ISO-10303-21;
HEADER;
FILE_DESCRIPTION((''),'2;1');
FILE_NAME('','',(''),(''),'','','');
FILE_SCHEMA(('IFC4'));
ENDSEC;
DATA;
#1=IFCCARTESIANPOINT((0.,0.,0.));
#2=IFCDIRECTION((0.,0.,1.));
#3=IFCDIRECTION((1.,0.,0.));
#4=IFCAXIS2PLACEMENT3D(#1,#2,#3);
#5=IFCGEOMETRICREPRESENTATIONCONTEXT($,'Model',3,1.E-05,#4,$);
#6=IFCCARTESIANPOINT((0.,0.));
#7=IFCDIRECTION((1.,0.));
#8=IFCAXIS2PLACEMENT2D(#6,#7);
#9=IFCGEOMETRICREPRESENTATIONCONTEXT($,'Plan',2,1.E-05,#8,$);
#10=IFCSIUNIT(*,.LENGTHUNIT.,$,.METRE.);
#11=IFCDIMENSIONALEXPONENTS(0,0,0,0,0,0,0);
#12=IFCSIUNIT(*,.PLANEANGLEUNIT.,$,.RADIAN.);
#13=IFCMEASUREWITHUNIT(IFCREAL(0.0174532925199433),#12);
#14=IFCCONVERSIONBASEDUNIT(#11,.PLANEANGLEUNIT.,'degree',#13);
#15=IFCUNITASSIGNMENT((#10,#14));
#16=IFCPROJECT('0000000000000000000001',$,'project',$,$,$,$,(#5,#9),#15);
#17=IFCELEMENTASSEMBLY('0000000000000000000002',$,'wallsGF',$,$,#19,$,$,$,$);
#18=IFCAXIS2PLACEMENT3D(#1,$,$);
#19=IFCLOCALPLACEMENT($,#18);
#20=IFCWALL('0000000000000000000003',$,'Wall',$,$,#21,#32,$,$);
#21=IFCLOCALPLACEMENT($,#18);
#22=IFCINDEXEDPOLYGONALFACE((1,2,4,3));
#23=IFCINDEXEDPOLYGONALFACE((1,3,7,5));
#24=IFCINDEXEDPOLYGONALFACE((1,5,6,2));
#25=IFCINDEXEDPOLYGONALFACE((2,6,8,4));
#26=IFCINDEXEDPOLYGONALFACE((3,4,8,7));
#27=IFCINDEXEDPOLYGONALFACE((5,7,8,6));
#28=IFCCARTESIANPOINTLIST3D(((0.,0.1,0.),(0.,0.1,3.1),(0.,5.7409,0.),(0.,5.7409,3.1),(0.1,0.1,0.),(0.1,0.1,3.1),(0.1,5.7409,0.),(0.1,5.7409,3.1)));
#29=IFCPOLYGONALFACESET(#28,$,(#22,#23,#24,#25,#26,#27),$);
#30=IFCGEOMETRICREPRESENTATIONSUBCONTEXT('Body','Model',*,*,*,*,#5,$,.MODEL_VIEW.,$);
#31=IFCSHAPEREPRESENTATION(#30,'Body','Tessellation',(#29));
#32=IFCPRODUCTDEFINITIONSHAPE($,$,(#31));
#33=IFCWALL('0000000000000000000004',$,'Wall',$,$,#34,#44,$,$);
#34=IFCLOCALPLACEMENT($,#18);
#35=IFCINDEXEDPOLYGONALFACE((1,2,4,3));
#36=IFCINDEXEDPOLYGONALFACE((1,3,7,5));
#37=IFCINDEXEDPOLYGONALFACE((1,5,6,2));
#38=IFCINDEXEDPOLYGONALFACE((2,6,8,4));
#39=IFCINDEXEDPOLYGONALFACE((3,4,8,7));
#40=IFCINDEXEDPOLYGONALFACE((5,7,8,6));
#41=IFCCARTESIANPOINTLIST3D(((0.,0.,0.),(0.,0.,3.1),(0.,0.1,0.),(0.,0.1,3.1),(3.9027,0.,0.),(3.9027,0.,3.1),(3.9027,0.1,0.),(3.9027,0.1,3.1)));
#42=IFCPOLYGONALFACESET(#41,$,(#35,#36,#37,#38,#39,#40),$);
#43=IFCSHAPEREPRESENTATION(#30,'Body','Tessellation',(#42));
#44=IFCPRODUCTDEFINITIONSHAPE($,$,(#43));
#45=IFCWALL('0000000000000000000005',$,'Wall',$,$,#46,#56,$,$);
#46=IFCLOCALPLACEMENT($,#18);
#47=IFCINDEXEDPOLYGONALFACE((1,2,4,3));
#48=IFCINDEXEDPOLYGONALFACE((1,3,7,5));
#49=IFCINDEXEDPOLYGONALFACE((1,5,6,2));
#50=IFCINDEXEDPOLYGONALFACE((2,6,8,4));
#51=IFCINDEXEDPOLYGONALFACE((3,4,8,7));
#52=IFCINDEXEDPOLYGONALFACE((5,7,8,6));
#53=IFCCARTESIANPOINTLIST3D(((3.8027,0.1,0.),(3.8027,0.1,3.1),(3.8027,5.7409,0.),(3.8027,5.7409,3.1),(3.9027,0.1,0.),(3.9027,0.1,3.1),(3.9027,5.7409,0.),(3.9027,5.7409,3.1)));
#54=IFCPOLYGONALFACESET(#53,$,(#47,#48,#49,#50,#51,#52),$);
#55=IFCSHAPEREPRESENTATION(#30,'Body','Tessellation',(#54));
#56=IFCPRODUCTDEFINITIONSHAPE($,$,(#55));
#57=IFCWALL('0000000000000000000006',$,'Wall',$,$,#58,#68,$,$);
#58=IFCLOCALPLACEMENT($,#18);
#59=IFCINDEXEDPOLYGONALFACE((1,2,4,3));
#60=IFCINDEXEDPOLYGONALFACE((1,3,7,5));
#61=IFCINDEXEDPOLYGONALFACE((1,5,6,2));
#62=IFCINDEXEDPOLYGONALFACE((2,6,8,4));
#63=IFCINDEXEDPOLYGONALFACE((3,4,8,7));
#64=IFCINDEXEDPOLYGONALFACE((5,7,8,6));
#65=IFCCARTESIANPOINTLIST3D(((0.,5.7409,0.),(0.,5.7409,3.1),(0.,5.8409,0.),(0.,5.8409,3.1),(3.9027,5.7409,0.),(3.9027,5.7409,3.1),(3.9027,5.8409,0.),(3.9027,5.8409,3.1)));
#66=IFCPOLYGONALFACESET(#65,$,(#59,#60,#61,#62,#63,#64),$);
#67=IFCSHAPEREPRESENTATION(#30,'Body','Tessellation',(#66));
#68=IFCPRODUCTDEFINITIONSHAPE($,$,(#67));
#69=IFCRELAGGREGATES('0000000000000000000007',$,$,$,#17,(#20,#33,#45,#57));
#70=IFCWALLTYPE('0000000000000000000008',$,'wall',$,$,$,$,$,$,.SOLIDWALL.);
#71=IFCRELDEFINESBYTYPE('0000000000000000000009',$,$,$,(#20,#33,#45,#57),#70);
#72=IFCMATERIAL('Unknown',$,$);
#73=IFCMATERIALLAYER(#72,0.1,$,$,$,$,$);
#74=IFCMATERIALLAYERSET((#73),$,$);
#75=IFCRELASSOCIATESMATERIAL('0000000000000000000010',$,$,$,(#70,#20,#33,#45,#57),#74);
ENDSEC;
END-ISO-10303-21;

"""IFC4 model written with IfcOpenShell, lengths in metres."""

from ifc_helpers import new_model, entity, si_unit, converted_unit, frame, origin_with_axes, origin_2d_with_axis, place, context, subcontext, project, indexed_curve, outline, extrude, clip, halfspace, material, layer, layer_set, layer_usage, type_object, element, aggregate, save


model = new_model("IFC4")

# Units and contexts
model_context = context("Model", 3, precision=1e-05, world=origin_with_axes())
plan_context = context("Plan", 2, precision=1e-05, world=origin_2d_with_axis())
body_context = subcontext(model_context, "Body", "Model", "MODEL_VIEW")
ifc_project = project(units=[si_unit("LENGTHUNIT", "METRE"), converted_unit("PLANEANGLEUNIT", "degree", entity("IfcReal", 0.0174532925199433), si_unit("PLANEANGLEUNIT", "RADIAN"), dimensions=[0, 0, 0, 0, 0, 0, 0])], contexts=[model_context, plan_context])

# Element assembly, walls
placement_1 = place(None, origin_with_axes())
placement_2 = place(placement_1, origin_with_axes())
placement_3 = place(placement_2, origin_with_axes())
assembly_placement = place(placement_3, origin_with_axes())
assembly = element("IfcElementAssembly", 1, at=assembly_placement, Name="wallsGF")
ifc_material = material(Name="Unknown")
ifc_layer = layer(ifc_material, 0.1)
ifc_layer_set = layer_set([ifc_layer])
ifc_layer_usage_1 = layer_usage(ifc_layer_set, "AXIS2", "POSITIVE", 0.0)
wall_type = type_object("IfcWallType", Name="wall", PredefinedType="SOLIDWALL", material=ifc_layer_set)
wall_1_placement = place(assembly_placement, frame((0.0, 5.7409, 0.0), z_axis=(0.0, 0.0, 1.0), x_axis=(0.0, -1.0, 0.0)))
wall_1 = element("IfcWall", 2, at=wall_1_placement, type_object=wall_type, material=ifc_layer_usage_1, Name="Wall", context=body_context, shape_type="Clipping", body=[
    clip(extrude(outline(indexed_curve([(0.0, 0.0), (0.0, 0.1), (5.6409, 0.1), (5.6409, 0.0), (0.0, 0.0)], self_intersect=False)), origin_with_axes(), (0.0, 0.0, 1.0), 3.1), halfspace(frame((0.0, 0.0, 3.1), z_axis=(0.0, 0.0, 1.0), x_axis=(-1.0, 0.0, 0.0)), False)),
])
ifc_layer_usage_2 = layer_usage(ifc_layer_set, "AXIS2", "POSITIVE", 0.0)
wall_2_placement = place(assembly_placement, origin_with_axes())
wall_2 = element("IfcWall", 3, at=wall_2_placement, type_object=wall_type, material=ifc_layer_usage_2, Name="Wall", context=body_context, shape_type="Clipping", body=[
    clip(extrude(outline(indexed_curve([(0.0, 0.0), (0.0, 0.1), (3.9027, 0.1), (3.9027, 0.0), (0.0, 0.0)], self_intersect=False)), origin_with_axes(), (0.0, 0.0, 1.0), 3.1), halfspace(frame((0.0, 0.0, 3.1), z_axis=(0.0, 0.0, 1.0), x_axis=(-1.0, 0.0, 0.0)), False)),
])
ifc_layer_usage_3 = layer_usage(ifc_layer_set, "AXIS2", "POSITIVE", 0.0)
wall_3_placement = place(assembly_placement, frame((3.8027, 5.7409, 0.0), z_axis=(0.0, 0.0, 1.0), x_axis=(0.0, -1.0, 0.0)))
wall_3 = element("IfcWall", 4, at=wall_3_placement, type_object=wall_type, material=ifc_layer_usage_3, Name="Wall", context=body_context, shape_type="Clipping", body=[
    clip(extrude(outline(indexed_curve([(0.0, 0.0), (0.0, 0.1), (5.6409, 0.1), (5.6409, 0.0), (0.0, 0.0)], self_intersect=False)), origin_with_axes(), (0.0, 0.0, 1.0), 3.1), halfspace(frame((0.0, 0.0, 3.1), z_axis=(0.0, 0.0, 1.0), x_axis=(-1.0, 0.0, 0.0)), False)),
])
ifc_layer_usage_4 = layer_usage(ifc_layer_set, "AXIS2", "POSITIVE", 0.0)
wall_4_placement = place(assembly_placement, frame((0.0, 5.7409, 0.0), z_axis=(0.0, 0.0, 1.0), x_axis=(1.0, 0.0, 0.0)))
wall_4 = element("IfcWall", 5, at=wall_4_placement, type_object=wall_type, material=ifc_layer_usage_4, Name="Wall", context=body_context, shape_type="Clipping", body=[
    clip(extrude(outline(indexed_curve([(0.0, 0.0), (0.0, 0.1), (3.9027, 0.1), (3.9027, 0.0), (0.0, 0.0)], self_intersect=False)), origin_with_axes(), (0.0, 0.0, 1.0), 3.1), halfspace(frame((0.0, 0.0, 3.1), z_axis=(0.0, 0.0, 1.0), x_axis=(-1.0, 0.0, 0.0)), False)),
])
aggregate(assembly, [wall_1, wall_2, wall_3, wall_4])

save(model, "model.ifc")
